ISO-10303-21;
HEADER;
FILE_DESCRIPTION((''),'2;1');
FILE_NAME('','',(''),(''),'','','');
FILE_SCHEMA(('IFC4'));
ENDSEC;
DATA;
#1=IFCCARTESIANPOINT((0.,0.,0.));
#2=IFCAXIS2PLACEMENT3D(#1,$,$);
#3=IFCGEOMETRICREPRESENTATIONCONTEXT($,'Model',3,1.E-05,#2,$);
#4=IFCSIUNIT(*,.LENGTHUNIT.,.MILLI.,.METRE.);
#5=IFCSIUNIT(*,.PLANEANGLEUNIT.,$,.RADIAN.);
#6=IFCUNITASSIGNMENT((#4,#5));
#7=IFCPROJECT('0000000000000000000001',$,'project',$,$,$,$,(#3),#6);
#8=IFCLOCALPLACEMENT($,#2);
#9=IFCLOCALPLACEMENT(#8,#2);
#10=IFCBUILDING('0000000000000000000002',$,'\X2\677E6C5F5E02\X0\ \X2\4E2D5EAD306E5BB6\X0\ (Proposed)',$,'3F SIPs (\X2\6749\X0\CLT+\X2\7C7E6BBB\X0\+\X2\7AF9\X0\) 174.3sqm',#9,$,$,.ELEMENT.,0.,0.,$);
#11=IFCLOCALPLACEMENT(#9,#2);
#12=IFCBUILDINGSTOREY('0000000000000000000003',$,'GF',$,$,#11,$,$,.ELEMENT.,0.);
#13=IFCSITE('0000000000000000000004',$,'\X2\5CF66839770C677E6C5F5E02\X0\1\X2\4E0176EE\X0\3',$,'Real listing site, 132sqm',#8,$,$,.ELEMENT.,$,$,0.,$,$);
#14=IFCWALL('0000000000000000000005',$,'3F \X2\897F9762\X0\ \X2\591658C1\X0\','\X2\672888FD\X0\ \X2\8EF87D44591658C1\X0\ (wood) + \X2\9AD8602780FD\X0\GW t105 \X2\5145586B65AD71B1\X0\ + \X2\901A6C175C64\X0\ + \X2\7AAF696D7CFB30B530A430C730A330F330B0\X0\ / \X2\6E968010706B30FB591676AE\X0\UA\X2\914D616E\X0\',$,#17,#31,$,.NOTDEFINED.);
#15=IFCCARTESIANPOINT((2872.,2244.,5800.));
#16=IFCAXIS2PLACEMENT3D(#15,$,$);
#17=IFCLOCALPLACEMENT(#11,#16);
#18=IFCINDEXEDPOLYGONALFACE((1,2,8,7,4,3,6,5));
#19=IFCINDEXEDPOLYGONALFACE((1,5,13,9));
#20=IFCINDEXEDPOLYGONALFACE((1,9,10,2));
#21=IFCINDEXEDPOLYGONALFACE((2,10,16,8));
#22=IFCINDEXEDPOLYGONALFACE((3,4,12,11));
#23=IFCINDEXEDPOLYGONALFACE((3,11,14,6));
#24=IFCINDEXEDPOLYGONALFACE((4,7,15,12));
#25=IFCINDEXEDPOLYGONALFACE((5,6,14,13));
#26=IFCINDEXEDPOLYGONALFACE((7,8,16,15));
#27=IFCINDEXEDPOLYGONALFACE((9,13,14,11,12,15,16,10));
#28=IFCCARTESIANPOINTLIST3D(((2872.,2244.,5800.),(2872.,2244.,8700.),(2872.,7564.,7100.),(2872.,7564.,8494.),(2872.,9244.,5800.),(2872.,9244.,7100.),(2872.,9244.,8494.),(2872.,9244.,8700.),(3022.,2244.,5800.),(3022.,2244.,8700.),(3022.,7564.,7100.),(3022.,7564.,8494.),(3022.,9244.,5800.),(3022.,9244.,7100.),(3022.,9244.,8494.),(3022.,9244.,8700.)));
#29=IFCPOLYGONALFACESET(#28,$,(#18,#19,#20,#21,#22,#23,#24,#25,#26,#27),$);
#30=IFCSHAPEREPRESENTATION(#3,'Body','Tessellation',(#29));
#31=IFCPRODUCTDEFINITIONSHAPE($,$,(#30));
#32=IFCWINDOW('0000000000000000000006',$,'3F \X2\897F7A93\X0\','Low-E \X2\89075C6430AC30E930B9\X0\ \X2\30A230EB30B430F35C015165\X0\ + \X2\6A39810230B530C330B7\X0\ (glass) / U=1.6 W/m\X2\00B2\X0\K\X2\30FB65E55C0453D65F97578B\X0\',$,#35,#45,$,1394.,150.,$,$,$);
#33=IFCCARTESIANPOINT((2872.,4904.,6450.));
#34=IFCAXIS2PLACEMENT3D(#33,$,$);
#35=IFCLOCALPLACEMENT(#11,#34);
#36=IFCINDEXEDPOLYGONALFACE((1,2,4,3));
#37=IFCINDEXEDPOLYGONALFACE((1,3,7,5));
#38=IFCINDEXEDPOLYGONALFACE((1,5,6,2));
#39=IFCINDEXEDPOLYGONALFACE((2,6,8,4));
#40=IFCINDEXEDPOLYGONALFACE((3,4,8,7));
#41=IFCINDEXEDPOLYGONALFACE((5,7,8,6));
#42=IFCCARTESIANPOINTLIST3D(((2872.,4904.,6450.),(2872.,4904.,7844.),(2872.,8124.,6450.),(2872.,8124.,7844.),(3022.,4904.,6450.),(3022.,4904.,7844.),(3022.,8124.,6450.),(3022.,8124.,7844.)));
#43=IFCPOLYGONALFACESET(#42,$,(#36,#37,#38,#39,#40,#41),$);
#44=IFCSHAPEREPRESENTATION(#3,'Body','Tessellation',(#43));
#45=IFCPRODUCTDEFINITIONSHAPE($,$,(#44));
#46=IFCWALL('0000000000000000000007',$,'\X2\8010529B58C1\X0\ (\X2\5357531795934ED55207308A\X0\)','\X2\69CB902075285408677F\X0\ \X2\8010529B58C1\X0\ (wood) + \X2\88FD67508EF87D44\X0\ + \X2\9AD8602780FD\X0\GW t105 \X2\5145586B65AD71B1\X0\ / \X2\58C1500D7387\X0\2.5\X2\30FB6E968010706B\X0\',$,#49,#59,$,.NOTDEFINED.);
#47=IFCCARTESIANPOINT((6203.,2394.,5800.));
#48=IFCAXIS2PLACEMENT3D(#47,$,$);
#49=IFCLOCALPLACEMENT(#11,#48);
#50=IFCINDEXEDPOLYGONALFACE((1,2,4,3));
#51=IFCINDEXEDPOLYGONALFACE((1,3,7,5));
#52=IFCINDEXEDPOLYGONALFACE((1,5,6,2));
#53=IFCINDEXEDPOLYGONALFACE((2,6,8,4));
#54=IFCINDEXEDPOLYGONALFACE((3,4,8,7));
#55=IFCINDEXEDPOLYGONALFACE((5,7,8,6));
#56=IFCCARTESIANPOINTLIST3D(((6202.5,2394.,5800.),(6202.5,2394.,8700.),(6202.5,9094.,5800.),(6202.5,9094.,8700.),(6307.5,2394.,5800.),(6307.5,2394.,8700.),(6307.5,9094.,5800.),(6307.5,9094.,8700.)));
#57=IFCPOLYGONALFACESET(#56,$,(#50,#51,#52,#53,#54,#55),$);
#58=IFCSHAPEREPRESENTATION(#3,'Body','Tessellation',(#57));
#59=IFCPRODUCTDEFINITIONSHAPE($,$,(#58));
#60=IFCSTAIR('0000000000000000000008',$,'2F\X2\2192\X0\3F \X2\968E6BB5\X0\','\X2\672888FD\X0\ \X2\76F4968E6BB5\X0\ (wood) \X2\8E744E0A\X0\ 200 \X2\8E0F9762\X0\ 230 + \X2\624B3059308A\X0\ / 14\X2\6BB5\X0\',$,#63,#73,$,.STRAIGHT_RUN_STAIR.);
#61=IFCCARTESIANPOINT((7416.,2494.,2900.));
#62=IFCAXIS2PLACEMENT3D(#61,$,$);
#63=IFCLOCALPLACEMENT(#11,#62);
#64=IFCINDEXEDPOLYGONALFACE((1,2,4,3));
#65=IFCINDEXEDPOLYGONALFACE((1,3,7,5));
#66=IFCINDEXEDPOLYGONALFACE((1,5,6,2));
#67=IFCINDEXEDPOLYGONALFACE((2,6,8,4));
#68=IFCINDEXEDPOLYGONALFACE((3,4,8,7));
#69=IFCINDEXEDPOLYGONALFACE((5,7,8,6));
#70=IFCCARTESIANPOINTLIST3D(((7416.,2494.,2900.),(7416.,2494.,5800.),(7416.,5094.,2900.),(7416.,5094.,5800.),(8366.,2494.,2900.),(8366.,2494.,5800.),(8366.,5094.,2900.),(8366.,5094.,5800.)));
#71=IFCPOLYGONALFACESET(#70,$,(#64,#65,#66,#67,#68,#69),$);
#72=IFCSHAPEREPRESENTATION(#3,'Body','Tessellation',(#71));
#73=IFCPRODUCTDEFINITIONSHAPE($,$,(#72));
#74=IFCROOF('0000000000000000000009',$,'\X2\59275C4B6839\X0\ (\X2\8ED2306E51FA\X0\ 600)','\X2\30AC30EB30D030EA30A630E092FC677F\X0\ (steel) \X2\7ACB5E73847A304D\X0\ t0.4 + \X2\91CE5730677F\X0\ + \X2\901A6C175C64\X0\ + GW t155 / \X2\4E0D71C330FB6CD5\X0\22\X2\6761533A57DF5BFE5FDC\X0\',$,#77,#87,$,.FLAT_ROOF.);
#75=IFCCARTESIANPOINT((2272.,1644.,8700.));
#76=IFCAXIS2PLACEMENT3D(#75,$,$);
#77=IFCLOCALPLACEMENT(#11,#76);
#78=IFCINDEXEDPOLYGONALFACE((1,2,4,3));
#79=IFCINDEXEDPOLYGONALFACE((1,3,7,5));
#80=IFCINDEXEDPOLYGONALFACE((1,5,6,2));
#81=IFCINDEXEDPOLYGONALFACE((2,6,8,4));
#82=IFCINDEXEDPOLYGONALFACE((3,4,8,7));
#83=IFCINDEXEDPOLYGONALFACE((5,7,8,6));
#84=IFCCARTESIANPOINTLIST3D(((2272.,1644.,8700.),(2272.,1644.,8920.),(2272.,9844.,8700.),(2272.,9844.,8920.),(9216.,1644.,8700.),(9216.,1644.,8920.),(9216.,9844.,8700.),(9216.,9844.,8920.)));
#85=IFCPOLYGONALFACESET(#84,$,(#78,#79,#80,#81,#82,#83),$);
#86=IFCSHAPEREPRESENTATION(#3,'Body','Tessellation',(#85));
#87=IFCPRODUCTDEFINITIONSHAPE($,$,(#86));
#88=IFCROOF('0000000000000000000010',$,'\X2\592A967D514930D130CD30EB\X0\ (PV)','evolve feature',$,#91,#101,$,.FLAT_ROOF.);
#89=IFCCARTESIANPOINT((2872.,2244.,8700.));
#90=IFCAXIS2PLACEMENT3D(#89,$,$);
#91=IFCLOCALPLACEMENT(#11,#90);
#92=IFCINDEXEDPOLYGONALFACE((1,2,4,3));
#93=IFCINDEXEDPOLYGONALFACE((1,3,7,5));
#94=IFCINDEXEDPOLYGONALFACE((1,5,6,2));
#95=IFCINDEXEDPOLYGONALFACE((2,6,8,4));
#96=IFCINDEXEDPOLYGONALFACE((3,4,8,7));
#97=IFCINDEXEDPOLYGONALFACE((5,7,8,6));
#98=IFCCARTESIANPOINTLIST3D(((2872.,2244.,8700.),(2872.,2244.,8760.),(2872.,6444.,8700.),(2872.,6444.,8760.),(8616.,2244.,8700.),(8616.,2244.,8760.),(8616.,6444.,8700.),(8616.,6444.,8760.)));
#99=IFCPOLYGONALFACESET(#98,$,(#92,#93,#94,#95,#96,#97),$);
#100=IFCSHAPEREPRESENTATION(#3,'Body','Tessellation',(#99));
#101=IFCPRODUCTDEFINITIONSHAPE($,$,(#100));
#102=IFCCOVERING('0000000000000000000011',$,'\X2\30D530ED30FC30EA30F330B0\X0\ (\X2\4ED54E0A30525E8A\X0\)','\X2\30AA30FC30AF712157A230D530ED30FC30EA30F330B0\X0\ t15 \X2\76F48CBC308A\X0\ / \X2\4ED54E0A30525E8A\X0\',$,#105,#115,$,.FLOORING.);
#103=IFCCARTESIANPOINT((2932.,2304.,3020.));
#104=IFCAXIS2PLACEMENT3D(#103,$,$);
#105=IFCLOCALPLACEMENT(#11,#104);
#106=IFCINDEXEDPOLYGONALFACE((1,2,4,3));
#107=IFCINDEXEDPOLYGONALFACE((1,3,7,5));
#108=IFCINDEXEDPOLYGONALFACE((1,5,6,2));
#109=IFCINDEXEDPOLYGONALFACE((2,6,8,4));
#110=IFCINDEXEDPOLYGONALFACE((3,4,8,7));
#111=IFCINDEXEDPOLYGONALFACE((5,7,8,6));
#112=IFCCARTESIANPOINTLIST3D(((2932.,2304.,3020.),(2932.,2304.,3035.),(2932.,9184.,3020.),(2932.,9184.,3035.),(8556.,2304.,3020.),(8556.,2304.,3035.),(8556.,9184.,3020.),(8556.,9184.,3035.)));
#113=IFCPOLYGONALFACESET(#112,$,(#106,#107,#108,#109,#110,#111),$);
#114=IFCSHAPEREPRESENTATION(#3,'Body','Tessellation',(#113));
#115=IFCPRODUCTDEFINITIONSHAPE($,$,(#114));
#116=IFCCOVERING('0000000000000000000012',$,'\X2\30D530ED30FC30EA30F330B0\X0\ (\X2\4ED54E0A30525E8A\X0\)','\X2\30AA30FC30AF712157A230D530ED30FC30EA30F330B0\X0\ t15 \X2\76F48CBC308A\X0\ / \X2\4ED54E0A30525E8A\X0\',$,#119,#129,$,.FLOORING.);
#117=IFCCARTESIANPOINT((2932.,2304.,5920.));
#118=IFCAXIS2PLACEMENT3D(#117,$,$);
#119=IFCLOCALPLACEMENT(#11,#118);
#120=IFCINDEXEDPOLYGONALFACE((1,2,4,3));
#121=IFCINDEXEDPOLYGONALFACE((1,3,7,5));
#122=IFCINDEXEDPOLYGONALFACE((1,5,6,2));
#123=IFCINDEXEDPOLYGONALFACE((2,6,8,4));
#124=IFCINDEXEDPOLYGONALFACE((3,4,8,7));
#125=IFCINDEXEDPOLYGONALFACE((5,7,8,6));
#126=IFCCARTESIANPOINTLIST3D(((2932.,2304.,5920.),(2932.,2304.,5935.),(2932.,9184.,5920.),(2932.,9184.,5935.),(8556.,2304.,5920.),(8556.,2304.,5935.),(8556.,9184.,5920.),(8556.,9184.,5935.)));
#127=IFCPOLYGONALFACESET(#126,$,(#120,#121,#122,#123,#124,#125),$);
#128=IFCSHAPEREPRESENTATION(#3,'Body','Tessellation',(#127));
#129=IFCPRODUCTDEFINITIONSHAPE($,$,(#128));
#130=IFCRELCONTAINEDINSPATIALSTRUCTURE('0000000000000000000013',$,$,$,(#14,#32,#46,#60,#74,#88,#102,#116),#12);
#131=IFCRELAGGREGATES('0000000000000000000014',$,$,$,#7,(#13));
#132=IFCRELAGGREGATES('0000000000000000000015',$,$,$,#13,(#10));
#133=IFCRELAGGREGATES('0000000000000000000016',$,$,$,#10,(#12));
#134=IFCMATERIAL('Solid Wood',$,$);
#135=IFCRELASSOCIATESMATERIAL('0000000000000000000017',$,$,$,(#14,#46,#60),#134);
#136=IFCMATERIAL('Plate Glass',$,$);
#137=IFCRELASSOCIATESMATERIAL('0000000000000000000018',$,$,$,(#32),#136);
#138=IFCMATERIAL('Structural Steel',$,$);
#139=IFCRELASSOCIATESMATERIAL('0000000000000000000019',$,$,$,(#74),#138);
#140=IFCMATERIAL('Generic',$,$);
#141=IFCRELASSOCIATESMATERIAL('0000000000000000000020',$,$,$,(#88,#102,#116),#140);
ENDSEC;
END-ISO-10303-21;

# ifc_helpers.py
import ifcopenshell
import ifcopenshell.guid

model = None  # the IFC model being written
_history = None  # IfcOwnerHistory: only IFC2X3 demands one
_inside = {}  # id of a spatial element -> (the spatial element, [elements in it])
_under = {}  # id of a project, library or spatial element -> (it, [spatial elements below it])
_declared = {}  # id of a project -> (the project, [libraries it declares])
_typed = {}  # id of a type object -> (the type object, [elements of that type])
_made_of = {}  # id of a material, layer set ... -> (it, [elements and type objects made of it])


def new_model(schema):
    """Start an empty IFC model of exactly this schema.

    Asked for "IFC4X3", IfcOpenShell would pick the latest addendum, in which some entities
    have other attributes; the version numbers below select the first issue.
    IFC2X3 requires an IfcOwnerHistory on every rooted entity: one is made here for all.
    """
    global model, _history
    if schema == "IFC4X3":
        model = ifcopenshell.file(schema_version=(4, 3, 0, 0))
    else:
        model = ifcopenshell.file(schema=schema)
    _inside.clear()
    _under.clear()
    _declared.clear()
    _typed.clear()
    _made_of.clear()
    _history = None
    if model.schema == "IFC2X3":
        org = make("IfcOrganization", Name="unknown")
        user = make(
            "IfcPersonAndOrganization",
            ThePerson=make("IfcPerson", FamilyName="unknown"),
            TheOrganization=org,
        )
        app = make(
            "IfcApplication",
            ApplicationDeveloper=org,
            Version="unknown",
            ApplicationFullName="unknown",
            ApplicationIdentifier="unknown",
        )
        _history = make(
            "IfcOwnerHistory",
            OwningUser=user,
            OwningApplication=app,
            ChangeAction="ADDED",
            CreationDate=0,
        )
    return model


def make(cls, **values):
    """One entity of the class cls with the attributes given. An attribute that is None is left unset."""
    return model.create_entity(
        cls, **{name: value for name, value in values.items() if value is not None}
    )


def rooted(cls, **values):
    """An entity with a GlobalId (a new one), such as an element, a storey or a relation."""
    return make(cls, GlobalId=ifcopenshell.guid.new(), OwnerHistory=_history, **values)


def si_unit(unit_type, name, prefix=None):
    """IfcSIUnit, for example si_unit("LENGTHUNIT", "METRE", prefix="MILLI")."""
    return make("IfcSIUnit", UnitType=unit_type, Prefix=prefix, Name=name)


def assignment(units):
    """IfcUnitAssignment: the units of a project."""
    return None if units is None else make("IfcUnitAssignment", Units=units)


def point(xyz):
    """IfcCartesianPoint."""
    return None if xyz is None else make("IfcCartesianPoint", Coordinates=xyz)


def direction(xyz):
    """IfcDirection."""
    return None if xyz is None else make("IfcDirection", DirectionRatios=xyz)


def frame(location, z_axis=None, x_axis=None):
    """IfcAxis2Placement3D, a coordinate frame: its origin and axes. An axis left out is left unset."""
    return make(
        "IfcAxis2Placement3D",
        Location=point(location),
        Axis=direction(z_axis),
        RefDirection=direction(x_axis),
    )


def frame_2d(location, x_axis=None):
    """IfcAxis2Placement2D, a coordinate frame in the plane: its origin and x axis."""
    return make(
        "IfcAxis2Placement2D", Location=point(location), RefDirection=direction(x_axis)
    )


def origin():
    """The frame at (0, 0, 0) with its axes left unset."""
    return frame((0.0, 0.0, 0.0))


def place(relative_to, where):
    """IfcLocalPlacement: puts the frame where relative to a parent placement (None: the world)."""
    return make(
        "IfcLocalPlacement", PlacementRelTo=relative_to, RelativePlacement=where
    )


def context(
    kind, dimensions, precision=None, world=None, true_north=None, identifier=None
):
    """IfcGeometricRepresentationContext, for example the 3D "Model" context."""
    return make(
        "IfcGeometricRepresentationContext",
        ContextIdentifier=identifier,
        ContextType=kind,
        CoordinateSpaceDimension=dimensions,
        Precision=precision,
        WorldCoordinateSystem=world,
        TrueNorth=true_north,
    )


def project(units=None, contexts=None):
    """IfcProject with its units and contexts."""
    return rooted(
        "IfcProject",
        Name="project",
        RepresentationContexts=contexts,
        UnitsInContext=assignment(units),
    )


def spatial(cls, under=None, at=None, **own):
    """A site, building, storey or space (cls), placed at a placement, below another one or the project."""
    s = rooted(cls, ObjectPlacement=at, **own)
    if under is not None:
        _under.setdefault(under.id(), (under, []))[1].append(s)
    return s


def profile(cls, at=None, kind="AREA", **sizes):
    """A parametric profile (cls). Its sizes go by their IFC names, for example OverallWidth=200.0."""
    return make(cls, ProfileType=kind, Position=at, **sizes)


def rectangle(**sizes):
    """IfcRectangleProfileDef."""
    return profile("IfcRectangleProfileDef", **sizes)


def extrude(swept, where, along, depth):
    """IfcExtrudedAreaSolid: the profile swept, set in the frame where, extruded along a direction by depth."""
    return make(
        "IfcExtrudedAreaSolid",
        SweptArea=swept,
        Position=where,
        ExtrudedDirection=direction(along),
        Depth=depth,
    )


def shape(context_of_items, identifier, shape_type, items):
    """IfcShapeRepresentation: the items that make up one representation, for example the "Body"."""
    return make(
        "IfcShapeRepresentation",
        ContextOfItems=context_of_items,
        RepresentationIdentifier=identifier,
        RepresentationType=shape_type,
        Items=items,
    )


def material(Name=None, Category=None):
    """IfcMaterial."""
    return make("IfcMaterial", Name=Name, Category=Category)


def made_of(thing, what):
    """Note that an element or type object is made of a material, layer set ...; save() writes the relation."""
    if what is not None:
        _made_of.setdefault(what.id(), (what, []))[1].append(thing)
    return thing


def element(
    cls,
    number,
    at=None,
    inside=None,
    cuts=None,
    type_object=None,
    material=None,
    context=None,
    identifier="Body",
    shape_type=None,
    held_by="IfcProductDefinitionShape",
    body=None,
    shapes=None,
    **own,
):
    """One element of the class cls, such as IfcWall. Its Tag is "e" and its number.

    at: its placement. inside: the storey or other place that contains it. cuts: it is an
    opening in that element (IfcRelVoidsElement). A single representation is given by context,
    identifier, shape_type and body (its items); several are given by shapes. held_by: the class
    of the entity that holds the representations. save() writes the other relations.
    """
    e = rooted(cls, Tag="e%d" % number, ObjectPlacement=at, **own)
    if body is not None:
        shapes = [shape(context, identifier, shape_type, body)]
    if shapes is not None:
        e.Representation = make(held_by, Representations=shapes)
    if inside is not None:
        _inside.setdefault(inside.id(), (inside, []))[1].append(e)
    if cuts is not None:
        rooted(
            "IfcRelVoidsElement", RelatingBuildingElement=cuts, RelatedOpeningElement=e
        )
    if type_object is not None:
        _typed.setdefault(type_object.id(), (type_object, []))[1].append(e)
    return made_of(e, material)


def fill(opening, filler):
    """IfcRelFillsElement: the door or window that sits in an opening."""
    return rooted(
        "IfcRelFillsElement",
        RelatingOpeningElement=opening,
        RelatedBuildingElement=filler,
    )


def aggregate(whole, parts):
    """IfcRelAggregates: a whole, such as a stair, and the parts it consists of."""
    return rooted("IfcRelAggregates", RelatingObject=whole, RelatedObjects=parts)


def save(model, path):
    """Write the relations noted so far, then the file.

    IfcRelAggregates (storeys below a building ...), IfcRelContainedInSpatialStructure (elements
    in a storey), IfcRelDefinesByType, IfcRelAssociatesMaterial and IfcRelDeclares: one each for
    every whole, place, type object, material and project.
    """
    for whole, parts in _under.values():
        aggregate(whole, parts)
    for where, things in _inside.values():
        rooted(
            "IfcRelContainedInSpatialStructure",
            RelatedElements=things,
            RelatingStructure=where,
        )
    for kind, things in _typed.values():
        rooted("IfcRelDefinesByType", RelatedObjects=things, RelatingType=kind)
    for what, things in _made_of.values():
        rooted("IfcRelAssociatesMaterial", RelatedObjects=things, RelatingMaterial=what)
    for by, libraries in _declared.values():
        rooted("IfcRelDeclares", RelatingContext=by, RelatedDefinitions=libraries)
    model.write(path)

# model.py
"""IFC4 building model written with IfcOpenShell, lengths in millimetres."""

from ifc_helpers import new_model, si_unit, frame, frame_2d, origin, place, context, project, spatial, rectangle, extrude, material, element, fill, save


model = new_model("IFC4")

# Units and contexts
model_context = context("Model", 3, precision=1e-05, world=origin())
ifc_project = project(units=[si_unit("LENGTHUNIT", "METRE", prefix="MILLI"), si_unit("PLANEANGLEUNIT", "RADIAN")], contexts=[model_context])

# Site, building, storey
site_placement = place(None, origin())
site = spatial("IfcSite", under=ifc_project, at=site_placement, Name="島根県松江市1丁目3", ObjectType="Real listing site, 132sqm", CompositionType="ELEMENT", RefElevation=0.0)
building_placement = place(site_placement, origin())
building = spatial("IfcBuilding", under=site, at=building_placement, Name="松江市 中庭の家 (Proposed)", ObjectType="3F SIPs (杉CLT+籾殻+竹) 174.3sqm", CompositionType="ELEMENT", ElevationOfRefHeight=0.0, ElevationOfTerrain=0.0)
storey_placement = place(building_placement, origin())
storey = spatial("IfcBuildingStorey", under=building, at=storey_placement, Name="GF", CompositionType="ELEMENT", Elevation=0.0)

# Shared definitions
ifc_material_1 = material(Name="Solid Wood")

# Shared definitions
ifc_material_2 = material(Name="Plate Glass")

# Shared definitions
ifc_material_3 = material(Name="Generic")

# Wall, opening, window
wall_1_placement = place(storey_placement, frame((2872.0, 2244.0, 5800.0)))
wall_1 = element("IfcWall", 1, at=wall_1_placement, inside=storey, material=ifc_material_1, Name="3F 西面 外壁", Description="木製 軸組外壁 (wood) + 高性能GW t105 充填断熱 + 通気層 + 窯業系サイディング / 準耐火・外皮UA配慮", PredefinedType="NOTDEFINED", context=model_context, shape_type="SweptSolid", body=[
    extrude(rectangle(XDim=150.0, YDim=7000.0, at=frame_2d((75.0, 3500.0))), frame((2872.0, 2244.0, 5800.0)), (0.0, 0.0, 1.0), 2900.0),
])
opening_1_placement = place(storey_placement, frame((2872.0, 4904.0, 6450.0)))
opening_1 = element("IfcOpeningElement", 2, at=opening_1_placement, cuts=wall_1, PredefinedType="NOTDEFINED", context=model_context, shape_type="SweptSolid", body=[
    extrude(rectangle(XDim=150.0, YDim=3220.0, at=frame_2d((75.0, 1610.0))), frame((2872.0, 4904.0, 6450.0)), (0.0, 0.0, 1.0), 1394.0),
])
window_1_placement = place(storey_placement, frame((2872.0, 4904.0, 6450.0)))
window_1 = element("IfcWindow", 3, at=window_1_placement, inside=storey, material=ifc_material_2, Name="3F 西窓", Description="Low-E 複層ガラス アルゴン封入 + 樹脂サッシ (glass) / U=1.6 W/m²K・日射取得型", OverallHeight=1394.0, OverallWidth=150.0, context=model_context, shape_type="SweptSolid", body=[
    extrude(rectangle(XDim=150.0, YDim=3220.0, at=frame_2d((75.0, 1610.0))), frame((2872.0, 4904.0, 6450.0)), (0.0, 0.0, 1.0), 1394.0),
])
fill(opening_1, window_1)

# Wall
wall_2_placement = place(storey_placement, frame((6203.0, 2394.0, 5800.0)))
element("IfcWall", 4, at=wall_2_placement, inside=storey, material=ifc_material_1, Name="耐力壁 (南北間仕切り)", Description="構造用合板 耐力壁 (wood) + 製材軸組 + 高性能GW t105 充填断熱 / 壁倍率2.5・準耐火", PredefinedType="NOTDEFINED", context=model_context, shape_type="SweptSolid", body=[
    extrude(rectangle(XDim=105.0, YDim=6700.0, at=frame_2d((52.0, 3350.0))), frame((6203.0, 2394.0, 5800.0)), (0.0, 0.0, 1.0), 2900.0),
])

# Stair
stair_placement = place(storey_placement, frame((7416.0, 2494.0, 2900.0)))
element("IfcStair", 5, at=stair_placement, inside=storey, material=ifc_material_1, Name="2F→3F 階段", Description="木製 直階段 (wood) 蹴上 200 踏面 230 + 手すり / 14段", PredefinedType="STRAIGHT_RUN_STAIR", context=model_context, shape_type="SweptSolid", body=[
    extrude(rectangle(XDim=950.0, YDim=2600.0, at=frame_2d((475.0, 1300.0))), frame((7416.0, 2494.0, 2900.0)), (0.0, 0.0, 1.0), 2900.0),
])

# Roofs
ifc_material_4 = material(Name="Structural Steel")
roof_1_placement = place(storey_placement, frame((2272.0, 1644.0, 8700.0)))
element("IfcRoof", 6, at=roof_1_placement, inside=storey, material=ifc_material_4, Name="大屋根 (軒の出 600)", Description="ガルバリウム鋼板 (steel) 立平葺き t0.4 + 野地板 + 通気層 + GW t155 / 不燃・法22条区域対応", PredefinedType="FLAT_ROOF", context=model_context, shape_type="SweptSolid", body=[
    extrude(rectangle(XDim=6944.0, YDim=8200.0, at=frame_2d((3472.0, 4100.0))), frame((2272.0, 1644.0, 8700.0)), (0.0, 0.0, 1.0), 220.0),
])
roof_2_placement = place(storey_placement, frame((2872.0, 2244.0, 8700.0)))
element("IfcRoof", 7, at=roof_2_placement, inside=storey, material=ifc_material_3, Name="太陽光パネル (PV)", Description="evolve feature", PredefinedType="FLAT_ROOF", context=model_context, shape_type="SweptSolid", body=[
    extrude(rectangle(XDim=5744.0, YDim=4200.0, at=frame_2d((2872.0, 2100.0))), frame((2872.0, 2244.0, 8700.0)), (0.0, 0.0, 1.0), 60.0),
])

# Coverings
covering_1_placement = place(storey_placement, frame((2932.0, 2304.0, 3020.0)))
element("IfcCovering", 8, at=covering_1_placement, inside=storey, material=ifc_material_3, Name="フローリング (仕上げ床)", Description="オーク無垢フローリング t15 直貼り / 仕上げ床", PredefinedType="FLOORING", context=model_context, shape_type="SweptSolid", body=[
    extrude(rectangle(XDim=5624.0, YDim=6880.0, at=frame_2d((2812.0, 3440.0))), frame((2932.0, 2304.0, 3020.0)), (0.0, 0.0, 1.0), 15.0),
])
covering_2_placement = place(storey_placement, frame((2932.0, 2304.0, 5920.0)))
element("IfcCovering", 9, at=covering_2_placement, inside=storey, material=ifc_material_3, Name="フローリング (仕上げ床)", Description="オーク無垢フローリング t15 直貼り / 仕上げ床", PredefinedType="FLOORING", context=model_context, shape_type="SweptSolid", body=[
    extrude(rectangle(XDim=5624.0, YDim=6880.0, at=frame_2d((2812.0, 3440.0))), frame((2932.0, 2304.0, 5920.0)), (0.0, 0.0, 1.0), 15.0),
])

save(model, "model.ifc")
